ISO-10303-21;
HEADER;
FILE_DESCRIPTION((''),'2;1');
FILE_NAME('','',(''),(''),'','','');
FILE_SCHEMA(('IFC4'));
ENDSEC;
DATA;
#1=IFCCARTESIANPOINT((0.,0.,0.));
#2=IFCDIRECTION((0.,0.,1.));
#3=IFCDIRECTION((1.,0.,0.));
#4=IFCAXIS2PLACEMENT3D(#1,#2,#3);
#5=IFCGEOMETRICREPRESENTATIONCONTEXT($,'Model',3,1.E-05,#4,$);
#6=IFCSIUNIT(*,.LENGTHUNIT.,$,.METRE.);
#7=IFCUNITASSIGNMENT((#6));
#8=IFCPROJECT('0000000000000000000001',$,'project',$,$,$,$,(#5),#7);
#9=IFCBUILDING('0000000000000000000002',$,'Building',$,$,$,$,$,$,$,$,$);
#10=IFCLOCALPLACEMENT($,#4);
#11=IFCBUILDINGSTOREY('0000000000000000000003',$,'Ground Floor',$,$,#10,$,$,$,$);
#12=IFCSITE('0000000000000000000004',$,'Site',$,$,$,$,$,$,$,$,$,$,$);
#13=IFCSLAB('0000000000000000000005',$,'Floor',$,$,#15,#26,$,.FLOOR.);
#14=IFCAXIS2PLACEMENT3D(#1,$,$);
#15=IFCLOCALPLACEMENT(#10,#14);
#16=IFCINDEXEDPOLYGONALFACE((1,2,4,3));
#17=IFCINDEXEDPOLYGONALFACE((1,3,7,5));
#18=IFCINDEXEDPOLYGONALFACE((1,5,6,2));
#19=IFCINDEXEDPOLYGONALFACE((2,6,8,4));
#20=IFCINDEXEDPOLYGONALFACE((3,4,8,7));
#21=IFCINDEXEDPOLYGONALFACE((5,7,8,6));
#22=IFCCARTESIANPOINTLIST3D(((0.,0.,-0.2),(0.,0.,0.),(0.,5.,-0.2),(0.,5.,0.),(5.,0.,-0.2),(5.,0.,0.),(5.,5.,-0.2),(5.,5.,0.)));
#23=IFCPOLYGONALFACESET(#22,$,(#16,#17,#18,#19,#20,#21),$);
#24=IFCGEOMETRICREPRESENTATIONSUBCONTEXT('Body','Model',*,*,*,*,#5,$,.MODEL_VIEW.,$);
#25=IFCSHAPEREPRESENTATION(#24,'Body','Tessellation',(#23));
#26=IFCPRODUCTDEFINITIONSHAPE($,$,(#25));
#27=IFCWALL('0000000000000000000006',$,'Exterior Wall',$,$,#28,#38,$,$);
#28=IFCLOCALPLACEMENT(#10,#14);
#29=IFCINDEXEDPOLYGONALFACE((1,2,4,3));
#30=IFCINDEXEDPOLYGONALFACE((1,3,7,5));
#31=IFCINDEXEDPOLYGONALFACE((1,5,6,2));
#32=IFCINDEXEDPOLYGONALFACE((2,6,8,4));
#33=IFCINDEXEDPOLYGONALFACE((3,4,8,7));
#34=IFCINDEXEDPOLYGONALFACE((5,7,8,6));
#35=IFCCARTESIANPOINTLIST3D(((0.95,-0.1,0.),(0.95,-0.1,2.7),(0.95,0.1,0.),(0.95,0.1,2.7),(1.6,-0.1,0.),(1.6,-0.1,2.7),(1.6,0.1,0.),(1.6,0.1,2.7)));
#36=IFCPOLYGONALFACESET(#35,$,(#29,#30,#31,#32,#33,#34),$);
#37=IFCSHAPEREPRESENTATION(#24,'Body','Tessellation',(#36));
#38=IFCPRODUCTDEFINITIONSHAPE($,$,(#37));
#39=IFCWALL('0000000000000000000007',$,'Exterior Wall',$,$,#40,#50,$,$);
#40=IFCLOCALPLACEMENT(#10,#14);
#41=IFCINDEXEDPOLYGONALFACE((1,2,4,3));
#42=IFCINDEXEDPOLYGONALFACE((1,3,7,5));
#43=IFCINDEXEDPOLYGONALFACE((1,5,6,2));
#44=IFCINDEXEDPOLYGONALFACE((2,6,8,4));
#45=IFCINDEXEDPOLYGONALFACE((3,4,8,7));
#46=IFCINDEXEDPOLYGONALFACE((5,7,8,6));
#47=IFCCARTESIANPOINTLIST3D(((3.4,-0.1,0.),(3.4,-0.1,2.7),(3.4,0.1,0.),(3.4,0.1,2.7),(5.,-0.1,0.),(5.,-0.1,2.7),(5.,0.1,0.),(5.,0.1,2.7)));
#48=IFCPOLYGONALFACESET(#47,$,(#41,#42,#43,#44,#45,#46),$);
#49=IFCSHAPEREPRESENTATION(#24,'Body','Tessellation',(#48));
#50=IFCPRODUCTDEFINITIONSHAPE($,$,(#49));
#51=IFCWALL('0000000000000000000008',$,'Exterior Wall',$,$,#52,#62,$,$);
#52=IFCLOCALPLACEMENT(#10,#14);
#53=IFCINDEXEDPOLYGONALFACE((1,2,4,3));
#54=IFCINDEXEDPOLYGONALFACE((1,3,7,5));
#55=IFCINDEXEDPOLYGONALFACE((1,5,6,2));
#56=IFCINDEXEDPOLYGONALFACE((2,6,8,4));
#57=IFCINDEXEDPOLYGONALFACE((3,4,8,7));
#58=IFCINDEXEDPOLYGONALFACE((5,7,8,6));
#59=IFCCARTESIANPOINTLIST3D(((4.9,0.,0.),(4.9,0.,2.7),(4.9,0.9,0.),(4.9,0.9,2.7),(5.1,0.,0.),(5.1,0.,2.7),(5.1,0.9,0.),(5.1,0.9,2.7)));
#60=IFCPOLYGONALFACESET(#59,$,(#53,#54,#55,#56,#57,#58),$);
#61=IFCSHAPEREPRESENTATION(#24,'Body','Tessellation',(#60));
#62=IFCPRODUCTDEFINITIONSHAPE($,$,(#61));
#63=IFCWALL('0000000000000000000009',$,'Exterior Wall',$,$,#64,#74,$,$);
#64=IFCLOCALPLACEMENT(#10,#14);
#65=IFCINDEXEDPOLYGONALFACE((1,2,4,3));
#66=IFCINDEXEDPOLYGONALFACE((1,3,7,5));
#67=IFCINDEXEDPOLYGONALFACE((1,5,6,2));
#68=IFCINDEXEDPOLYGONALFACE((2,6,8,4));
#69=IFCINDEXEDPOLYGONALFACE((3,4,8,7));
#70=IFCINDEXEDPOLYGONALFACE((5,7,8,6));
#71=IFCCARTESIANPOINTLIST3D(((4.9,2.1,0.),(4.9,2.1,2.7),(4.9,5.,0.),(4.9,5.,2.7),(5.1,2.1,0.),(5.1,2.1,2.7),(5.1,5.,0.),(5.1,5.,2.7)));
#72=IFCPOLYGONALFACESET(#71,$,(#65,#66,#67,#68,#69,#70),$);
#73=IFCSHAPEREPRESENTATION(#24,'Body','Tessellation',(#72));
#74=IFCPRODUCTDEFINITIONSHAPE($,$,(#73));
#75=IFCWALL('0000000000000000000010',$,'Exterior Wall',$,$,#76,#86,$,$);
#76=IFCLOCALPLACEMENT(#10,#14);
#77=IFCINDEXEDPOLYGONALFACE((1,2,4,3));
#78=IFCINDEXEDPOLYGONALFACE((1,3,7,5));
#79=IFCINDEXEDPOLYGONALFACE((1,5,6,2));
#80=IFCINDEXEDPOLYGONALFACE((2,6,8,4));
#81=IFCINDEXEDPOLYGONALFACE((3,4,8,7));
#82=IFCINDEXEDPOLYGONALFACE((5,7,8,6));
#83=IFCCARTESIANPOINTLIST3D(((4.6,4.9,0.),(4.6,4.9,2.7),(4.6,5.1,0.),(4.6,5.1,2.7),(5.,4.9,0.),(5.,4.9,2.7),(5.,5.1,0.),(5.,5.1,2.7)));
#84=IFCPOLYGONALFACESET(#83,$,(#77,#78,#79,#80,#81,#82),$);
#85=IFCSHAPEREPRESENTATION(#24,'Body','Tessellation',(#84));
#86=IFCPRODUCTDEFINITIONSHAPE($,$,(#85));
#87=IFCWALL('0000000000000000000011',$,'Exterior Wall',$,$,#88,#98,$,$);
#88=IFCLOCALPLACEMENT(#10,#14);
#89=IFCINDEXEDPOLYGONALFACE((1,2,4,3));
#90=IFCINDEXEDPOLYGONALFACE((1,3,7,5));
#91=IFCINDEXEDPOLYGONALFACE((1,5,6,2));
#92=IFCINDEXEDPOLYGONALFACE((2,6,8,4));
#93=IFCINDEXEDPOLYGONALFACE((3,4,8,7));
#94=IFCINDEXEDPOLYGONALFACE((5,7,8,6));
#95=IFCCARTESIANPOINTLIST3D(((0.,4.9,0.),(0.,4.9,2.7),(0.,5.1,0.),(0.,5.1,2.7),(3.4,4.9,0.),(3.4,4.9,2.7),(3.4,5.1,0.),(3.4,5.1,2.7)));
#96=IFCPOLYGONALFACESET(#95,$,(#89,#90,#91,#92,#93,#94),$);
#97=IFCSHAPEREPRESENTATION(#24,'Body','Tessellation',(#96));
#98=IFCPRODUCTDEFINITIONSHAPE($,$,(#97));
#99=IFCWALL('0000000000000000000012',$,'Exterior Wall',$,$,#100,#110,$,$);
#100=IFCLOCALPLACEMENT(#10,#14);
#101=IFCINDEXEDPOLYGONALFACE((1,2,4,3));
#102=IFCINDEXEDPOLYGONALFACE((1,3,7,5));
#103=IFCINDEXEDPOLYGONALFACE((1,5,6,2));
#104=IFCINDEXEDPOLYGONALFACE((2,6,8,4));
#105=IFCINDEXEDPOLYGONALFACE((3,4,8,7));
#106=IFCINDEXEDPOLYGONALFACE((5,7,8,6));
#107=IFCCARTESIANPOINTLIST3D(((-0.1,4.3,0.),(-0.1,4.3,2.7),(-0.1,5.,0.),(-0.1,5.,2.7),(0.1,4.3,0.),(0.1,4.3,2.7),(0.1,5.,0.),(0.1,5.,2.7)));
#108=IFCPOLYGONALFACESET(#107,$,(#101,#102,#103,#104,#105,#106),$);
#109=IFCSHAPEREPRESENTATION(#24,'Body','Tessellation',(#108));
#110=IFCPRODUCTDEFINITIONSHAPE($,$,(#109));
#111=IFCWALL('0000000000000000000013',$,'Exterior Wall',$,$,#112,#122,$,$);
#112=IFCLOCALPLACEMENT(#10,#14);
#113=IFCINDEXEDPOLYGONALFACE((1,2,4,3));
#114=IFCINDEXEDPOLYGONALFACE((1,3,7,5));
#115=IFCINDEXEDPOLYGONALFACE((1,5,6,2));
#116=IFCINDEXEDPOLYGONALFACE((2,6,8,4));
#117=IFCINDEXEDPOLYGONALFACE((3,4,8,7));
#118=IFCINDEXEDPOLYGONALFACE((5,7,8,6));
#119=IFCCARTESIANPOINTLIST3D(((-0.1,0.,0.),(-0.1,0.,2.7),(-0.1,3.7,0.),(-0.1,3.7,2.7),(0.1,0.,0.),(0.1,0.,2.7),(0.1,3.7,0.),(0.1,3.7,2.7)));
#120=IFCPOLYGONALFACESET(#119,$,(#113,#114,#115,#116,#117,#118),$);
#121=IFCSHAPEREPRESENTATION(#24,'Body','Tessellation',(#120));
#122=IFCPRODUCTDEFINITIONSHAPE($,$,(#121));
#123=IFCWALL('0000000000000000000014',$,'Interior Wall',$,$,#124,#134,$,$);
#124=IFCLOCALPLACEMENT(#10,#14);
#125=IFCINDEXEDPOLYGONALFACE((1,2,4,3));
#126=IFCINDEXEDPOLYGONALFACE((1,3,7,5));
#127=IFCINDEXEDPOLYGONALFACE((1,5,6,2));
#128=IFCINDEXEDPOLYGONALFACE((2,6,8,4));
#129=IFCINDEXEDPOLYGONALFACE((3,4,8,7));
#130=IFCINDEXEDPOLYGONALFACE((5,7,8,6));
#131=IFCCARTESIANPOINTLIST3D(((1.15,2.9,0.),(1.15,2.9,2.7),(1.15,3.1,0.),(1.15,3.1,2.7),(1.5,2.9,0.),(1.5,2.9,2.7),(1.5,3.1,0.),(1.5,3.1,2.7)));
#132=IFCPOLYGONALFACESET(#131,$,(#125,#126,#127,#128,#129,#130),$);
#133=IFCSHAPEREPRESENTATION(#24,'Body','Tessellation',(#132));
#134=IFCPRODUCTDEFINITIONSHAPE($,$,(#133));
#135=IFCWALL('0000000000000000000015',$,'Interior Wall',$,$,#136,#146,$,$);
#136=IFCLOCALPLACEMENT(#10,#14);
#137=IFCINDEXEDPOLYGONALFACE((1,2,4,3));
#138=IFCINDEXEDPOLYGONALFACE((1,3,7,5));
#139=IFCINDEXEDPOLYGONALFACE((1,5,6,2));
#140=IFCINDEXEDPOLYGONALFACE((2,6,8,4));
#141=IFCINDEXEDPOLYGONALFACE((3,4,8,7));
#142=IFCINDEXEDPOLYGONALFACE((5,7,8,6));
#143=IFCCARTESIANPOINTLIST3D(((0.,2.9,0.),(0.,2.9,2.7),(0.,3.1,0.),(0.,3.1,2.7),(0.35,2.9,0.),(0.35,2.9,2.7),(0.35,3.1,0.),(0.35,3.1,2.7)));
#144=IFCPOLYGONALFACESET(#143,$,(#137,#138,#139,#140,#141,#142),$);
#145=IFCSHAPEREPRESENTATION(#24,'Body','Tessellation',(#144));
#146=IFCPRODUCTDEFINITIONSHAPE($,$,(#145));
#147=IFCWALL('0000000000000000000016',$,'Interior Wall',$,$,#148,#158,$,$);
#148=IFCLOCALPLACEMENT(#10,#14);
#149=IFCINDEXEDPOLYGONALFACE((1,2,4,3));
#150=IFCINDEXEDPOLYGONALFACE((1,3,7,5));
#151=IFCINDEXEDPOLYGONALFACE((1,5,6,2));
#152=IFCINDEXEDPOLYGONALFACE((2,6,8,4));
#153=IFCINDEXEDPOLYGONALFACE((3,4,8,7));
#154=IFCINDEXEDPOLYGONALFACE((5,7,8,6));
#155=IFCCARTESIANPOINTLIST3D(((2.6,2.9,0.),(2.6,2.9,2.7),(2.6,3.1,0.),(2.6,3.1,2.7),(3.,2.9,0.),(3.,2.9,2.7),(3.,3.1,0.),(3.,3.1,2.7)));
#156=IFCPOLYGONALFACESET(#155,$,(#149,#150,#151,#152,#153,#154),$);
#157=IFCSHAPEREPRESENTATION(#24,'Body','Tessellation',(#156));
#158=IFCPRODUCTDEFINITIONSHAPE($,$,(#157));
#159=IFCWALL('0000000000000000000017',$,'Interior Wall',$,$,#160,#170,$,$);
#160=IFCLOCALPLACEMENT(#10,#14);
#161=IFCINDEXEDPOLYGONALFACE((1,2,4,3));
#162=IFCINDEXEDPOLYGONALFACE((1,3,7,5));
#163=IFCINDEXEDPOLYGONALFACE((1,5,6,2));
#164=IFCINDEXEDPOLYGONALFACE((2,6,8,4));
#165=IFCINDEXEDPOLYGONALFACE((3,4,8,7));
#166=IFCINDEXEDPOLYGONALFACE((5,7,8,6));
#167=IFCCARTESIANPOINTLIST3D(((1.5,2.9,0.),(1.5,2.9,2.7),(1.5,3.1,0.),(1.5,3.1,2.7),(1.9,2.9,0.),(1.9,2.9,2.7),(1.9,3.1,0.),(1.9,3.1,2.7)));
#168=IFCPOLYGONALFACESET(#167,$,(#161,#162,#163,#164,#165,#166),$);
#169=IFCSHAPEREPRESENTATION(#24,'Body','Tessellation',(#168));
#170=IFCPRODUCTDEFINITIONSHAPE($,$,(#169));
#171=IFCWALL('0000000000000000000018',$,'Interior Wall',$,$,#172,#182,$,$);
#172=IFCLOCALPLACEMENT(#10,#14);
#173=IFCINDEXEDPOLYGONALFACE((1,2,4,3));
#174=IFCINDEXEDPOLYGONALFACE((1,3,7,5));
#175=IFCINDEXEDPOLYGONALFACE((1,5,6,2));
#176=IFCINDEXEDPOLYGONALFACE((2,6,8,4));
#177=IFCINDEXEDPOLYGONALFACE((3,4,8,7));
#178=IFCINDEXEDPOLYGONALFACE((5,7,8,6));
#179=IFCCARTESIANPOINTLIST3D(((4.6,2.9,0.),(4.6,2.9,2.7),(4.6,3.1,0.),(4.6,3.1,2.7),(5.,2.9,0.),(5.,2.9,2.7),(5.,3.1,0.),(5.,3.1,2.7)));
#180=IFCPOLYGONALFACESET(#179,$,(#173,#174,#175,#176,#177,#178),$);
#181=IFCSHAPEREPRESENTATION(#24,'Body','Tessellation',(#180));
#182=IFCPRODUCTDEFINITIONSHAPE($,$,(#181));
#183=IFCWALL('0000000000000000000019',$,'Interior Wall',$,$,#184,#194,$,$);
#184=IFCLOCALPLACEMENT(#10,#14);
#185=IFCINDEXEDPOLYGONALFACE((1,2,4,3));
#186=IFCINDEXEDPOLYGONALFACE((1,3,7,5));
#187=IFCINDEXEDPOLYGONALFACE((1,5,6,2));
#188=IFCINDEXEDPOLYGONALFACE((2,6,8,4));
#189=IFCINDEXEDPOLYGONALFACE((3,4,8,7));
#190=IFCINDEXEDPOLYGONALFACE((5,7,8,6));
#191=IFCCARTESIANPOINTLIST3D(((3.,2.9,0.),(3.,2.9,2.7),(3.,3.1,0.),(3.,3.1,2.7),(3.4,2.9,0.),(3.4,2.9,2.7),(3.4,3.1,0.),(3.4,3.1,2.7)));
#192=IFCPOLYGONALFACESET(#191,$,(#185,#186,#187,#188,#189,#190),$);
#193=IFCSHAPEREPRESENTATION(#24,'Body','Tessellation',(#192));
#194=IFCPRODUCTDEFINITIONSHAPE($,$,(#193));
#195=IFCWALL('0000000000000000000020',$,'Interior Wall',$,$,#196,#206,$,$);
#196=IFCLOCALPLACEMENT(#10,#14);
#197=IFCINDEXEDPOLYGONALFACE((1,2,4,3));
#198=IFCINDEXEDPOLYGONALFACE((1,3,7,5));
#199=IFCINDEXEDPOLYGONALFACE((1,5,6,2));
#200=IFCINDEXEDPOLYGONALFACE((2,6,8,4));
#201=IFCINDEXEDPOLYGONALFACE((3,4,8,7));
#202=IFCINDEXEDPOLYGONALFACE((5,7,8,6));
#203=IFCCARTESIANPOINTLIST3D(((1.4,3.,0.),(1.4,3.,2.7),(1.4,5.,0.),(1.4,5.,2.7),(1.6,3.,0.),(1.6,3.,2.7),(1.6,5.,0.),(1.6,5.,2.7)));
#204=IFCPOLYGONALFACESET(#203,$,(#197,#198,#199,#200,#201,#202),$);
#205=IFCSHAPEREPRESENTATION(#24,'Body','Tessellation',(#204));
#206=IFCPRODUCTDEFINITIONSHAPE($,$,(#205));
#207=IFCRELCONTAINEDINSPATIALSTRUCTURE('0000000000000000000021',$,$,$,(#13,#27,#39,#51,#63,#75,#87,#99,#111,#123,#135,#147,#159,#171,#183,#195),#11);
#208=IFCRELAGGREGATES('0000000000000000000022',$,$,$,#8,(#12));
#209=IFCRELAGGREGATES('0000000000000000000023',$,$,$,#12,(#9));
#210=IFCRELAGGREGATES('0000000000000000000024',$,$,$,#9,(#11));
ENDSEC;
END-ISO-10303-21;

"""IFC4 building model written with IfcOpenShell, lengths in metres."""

from ifc_helpers import new_model, si_unit, frame, origin_with_axes, place, context, subcontext, project, spatial, indexed_curve, outline, extrude, element, save


model = new_model("IFC4")

# Units and contexts
model_context = context("Model", 3, precision=1e-05, world=origin_with_axes())
body_context = subcontext(model_context, "Body", "Model", "MODEL_VIEW")
ifc_project = project(units=[si_unit("LENGTHUNIT", "METRE")], contexts=[model_context])

# Site, building, storey
site = spatial("IfcSite", under=ifc_project, Name="Site")
building = spatial("IfcBuilding", under=site, Name="Building")
storey_placement = place(None, origin_with_axes())
storey = spatial("IfcBuildingStorey", under=building, at=storey_placement, Name="Ground Floor")

# Slab
slab_placement = place(storey_placement, frame((0.0, 0.0, -0.2), z_axis=(0.0, 0.0, 1.0), x_axis=(1.0, 0.0, 0.0)))
element("IfcSlab", 1, at=slab_placement, inside=storey, Name="Floor", PredefinedType="FLOOR", context=body_context, shape_type="SweptSolid", body=[
    extrude(outline(indexed_curve([(0.0, 0.0), (5.0, 0.0), (5.0, 5.0), (0.0, 5.0)])), None, (0.0, 0.0, 1.0), 0.2),
])

# Walls
wall_1_placement = place(storey_placement, frame((0.95, 0.0, 0.0), z_axis=(0.0, 0.0, 1.0), x_axis=(1.0, 0.0, 0.0)))
element("IfcWall", 2, at=wall_1_placement, inside=storey, Name="Exterior Wall", context=body_context, shape_type="SweptSolid", body=[
    extrude(outline(indexed_curve([(0.0, 0.0), (0.0, 0.2), (0.65, 0.2), (0.65, 0.0), (0.0, 0.0)], self_intersect=False)), frame((0.0, -0.1, 0.0), z_axis=(0.0, 0.0, 1.0), x_axis=(1.0, 0.0, 0.0)), (0.0, 0.0, 1.0), 2.7),
])
wall_2_placement = place(storey_placement, frame((3.4, 0.0, 0.0), z_axis=(0.0, 0.0, 1.0), x_axis=(1.0, 0.0, 0.0)))
element("IfcWall", 3, at=wall_2_placement, inside=storey, Name="Exterior Wall", context=body_context, shape_type="SweptSolid", body=[
    extrude(outline(indexed_curve([(0.0, 0.0), (0.0, 0.2), (1.6, 0.2), (1.6, 0.0), (0.0, 0.0)], self_intersect=False)), frame((0.0, -0.1, 0.0), z_axis=(0.0, 0.0, 1.0), x_axis=(1.0, 0.0, 0.0)), (0.0, 0.0, 1.0), 2.7),
])
wall_3_placement = place(storey_placement, frame((5.0, 0.0, 0.0), z_axis=(0.0, 0.0, 1.0), x_axis=(0.0, 1.0, 0.0)))
element("IfcWall", 4, at=wall_3_placement, inside=storey, Name="Exterior Wall", context=body_context, shape_type="SweptSolid", body=[
    extrude(outline(indexed_curve([(0.0, 0.0), (0.0, 0.2), (0.9, 0.2), (0.9, 0.0), (0.0, 0.0)], self_intersect=False)), frame((0.0, -0.1, 0.0), z_axis=(0.0, 0.0, 1.0), x_axis=(1.0, 0.0, 0.0)), (0.0, 0.0, 1.0), 2.7),
])
wall_4_placement = place(storey_placement, frame((5.0, 2.1, 0.0), z_axis=(0.0, 0.0, 1.0), x_axis=(0.0, 1.0, 0.0)))
element("IfcWall", 5, at=wall_4_placement, inside=storey, Name="Exterior Wall", context=body_context, shape_type="SweptSolid", body=[
    extrude(outline(indexed_curve([(0.0, 0.0), (0.0, 0.2), (2.9, 0.2), (2.9, 0.0), (0.0, 0.0)], self_intersect=False)), frame((0.0, -0.1, 0.0), z_axis=(0.0, 0.0, 1.0), x_axis=(1.0, 0.0, 0.0)), (0.0, 0.0, 1.0), 2.7),
])
wall_5_placement = place(storey_placement, frame((5.0, 5.0, 0.0), z_axis=(0.0, 0.0, 1.0), x_axis=(-1.0, 0.0, 0.0)))
element("IfcWall", 6, at=wall_5_placement, inside=storey, Name="Exterior Wall", context=body_context, shape_type="SweptSolid", body=[
    extrude(outline(indexed_curve([(0.0, 0.0), (0.0, 0.2), (0.4, 0.2), (0.4, 0.0), (0.0, 0.0)], self_intersect=False)), frame((0.0, -0.1, 0.0), z_axis=(0.0, 0.0, 1.0), x_axis=(1.0, 0.0, 0.0)), (0.0, 0.0, 1.0), 2.7),
])
wall_6_placement = place(storey_placement, frame((3.4, 5.0, 0.0), z_axis=(0.0, 0.0, 1.0), x_axis=(-1.0, 0.0, 0.0)))
element("IfcWall", 7, at=wall_6_placement, inside=storey, Name="Exterior Wall", context=body_context, shape_type="SweptSolid", body=[
    extrude(outline(indexed_curve([(0.0, 0.0), (0.0, 0.2), (3.4, 0.2), (3.4, 0.0), (0.0, 0.0)], self_intersect=False)), frame((0.0, -0.1, 0.0), z_axis=(0.0, 0.0, 1.0), x_axis=(1.0, 0.0, 0.0)), (0.0, 0.0, 1.0), 2.7),
])
wall_7_placement = place(storey_placement, frame((0.0, 5.0, 0.0), z_axis=(0.0, 0.0, 1.0), x_axis=(0.0, -1.0, 0.0)))
element("IfcWall", 8, at=wall_7_placement, inside=storey, Name="Exterior Wall", context=body_context, shape_type="SweptSolid", body=[
    extrude(outline(indexed_curve([(0.0, 0.0), (0.0, 0.2), (0.7, 0.2), (0.7, 0.0), (0.0, 0.0)], self_intersect=False)), frame((0.0, -0.1, 0.0), z_axis=(0.0, 0.0, 1.0), x_axis=(1.0, 0.0, 0.0)), (0.0, 0.0, 1.0), 2.7),
])
wall_8_placement = place(storey_placement, frame((0.0, 3.7, 0.0), z_axis=(0.0, 0.0, 1.0), x_axis=(0.0, -1.0, 0.0)))
element("IfcWall", 9, at=wall_8_placement, inside=storey, Name="Exterior Wall", context=body_context, shape_type="SweptSolid", body=[
    extrude(outline(indexed_curve([(0.0, 0.0), (0.0, 0.2), (3.7, 0.2), (3.7, 0.0), (0.0, 0.0)], self_intersect=False)), frame((0.0, -0.1, 0.0), z_axis=(0.0, 0.0, 1.0), x_axis=(1.0, 0.0, 0.0)), (0.0, 0.0, 1.0), 2.7),
])
for number, where, z_axis, x_axis, name in (
    (10, (1.5, 3.0, 0.0), (0.0, 0.0, 1.0), (-1.0, 0.0, 0.0), "Interior Wall"),
    (11, (0.35, 3.0, 0.0), (0.0, 0.0, 1.0), (-1.0, 0.0, 0.0), "Interior Wall"),
):
    element("IfcWall", number, at=place(storey_placement, frame(where, z_axis=z_axis, x_axis=x_axis)), inside=storey, Name=name, context=body_context, shape_type="SweptSolid", body=[
        extrude(outline(indexed_curve([(0.0, 0.0), (0.0, 0.2), (0.35, 0.2), (0.35, 0.0), (0.0, 0.0)], self_intersect=False)), frame((0.0, -0.1, 0.0), z_axis=(0.0, 0.0, 1.0), x_axis=(1.0, 0.0, 0.0)), (0.0, 0.0, 1.0), 2.7),
    ])
for number, where, z_axis, x_axis, name in (
    (12, (3.0, 3.0, 0.0), (0.0, 0.0, 1.0), (-1.0, 0.0, 0.0), "Interior Wall"),
    (13, (1.9, 3.0, 0.0), (0.0, 0.0, 1.0), (-1.0, 0.0, 0.0), "Interior Wall"),
):
    element("IfcWall", number, at=place(storey_placement, frame(where, z_axis=z_axis, x_axis=x_axis)), inside=storey, Name=name, context=body_context, shape_type="SweptSolid", body=[
        extrude(outline(indexed_curve([(0.0, 0.0), (0.0, 0.2), (0.4, 0.2), (0.4, 0.0), (0.0, 0.0)], self_intersect=False)), frame((0.0, -0.1, 0.0), z_axis=(0.0, 0.0, 1.0), x_axis=(1.0, 0.0, 0.0)), (0.0, 0.0, 1.0), 2.7),
    ])
wall_9_placement = place(storey_placement, frame((5.0, 3.0, 0.0), z_axis=(0.0, 0.0, 1.0), x_axis=(-1.0, 0.0, 0.0)))
element("IfcWall", 14, at=wall_9_placement, inside=storey, Name="Interior Wall", context=body_context, shape_type="SweptSolid", body=[
    extrude(outline(indexed_curve([(0.0, 0.0), (0.0, 0.2), (0.4, 0.2), (0.4, 0.0), (0.0, 0.0)], self_intersect=False)), frame((0.0, -0.1, 0.0), z_axis=(0.0, 0.0, 1.0), x_axis=(1.0, 0.0, 0.0)), (0.0, 0.0, 1.0), 2.7),
])
wall_10_placement = place(storey_placement, frame((3.4, 3.0, 0.0), z_axis=(0.0, 0.0, 1.0), x_axis=(-1.0, 0.0, 0.0)))
element("IfcWall", 15, at=wall_10_placement, inside=storey, Name="Interior Wall", context=body_context, shape_type="SweptSolid", body=[
    extrude(outline(indexed_curve([(0.0, 0.0), (0.0, 0.2), (0.4, 0.2), (0.4, 0.0), (0.0, 0.0)], self_intersect=False)), frame((0.0, -0.1, 0.0), z_axis=(0.0, 0.0, 1.0), x_axis=(1.0, 0.0, 0.0)), (0.0, 0.0, 1.0), 2.7),
])
for number, where, z_axis, x_axis, name in (
    (16, (1.5, 3.0, 0.0), (0.0, 0.0, 1.0), (0.0, 1.0, 0.0), "Interior Wall"),
):
    element("IfcWall", number, at=place(storey_placement, frame(where, z_axis=z_axis, x_axis=x_axis)), inside=storey, Name=name, context=body_context, shape_type="SweptSolid", body=[
        extrude(outline(indexed_curve([(0.0, 0.0), (0.0, 0.2), (2.0, 0.2), (2.0, 0.0), (0.0, 0.0)], self_intersect=False)), frame((0.0, -0.1, 0.0), z_axis=(0.0, 0.0, 1.0), x_axis=(1.0, 0.0, 0.0)), (0.0, 0.0, 1.0), 2.7),
    ])

save(model, "model.ifc")
